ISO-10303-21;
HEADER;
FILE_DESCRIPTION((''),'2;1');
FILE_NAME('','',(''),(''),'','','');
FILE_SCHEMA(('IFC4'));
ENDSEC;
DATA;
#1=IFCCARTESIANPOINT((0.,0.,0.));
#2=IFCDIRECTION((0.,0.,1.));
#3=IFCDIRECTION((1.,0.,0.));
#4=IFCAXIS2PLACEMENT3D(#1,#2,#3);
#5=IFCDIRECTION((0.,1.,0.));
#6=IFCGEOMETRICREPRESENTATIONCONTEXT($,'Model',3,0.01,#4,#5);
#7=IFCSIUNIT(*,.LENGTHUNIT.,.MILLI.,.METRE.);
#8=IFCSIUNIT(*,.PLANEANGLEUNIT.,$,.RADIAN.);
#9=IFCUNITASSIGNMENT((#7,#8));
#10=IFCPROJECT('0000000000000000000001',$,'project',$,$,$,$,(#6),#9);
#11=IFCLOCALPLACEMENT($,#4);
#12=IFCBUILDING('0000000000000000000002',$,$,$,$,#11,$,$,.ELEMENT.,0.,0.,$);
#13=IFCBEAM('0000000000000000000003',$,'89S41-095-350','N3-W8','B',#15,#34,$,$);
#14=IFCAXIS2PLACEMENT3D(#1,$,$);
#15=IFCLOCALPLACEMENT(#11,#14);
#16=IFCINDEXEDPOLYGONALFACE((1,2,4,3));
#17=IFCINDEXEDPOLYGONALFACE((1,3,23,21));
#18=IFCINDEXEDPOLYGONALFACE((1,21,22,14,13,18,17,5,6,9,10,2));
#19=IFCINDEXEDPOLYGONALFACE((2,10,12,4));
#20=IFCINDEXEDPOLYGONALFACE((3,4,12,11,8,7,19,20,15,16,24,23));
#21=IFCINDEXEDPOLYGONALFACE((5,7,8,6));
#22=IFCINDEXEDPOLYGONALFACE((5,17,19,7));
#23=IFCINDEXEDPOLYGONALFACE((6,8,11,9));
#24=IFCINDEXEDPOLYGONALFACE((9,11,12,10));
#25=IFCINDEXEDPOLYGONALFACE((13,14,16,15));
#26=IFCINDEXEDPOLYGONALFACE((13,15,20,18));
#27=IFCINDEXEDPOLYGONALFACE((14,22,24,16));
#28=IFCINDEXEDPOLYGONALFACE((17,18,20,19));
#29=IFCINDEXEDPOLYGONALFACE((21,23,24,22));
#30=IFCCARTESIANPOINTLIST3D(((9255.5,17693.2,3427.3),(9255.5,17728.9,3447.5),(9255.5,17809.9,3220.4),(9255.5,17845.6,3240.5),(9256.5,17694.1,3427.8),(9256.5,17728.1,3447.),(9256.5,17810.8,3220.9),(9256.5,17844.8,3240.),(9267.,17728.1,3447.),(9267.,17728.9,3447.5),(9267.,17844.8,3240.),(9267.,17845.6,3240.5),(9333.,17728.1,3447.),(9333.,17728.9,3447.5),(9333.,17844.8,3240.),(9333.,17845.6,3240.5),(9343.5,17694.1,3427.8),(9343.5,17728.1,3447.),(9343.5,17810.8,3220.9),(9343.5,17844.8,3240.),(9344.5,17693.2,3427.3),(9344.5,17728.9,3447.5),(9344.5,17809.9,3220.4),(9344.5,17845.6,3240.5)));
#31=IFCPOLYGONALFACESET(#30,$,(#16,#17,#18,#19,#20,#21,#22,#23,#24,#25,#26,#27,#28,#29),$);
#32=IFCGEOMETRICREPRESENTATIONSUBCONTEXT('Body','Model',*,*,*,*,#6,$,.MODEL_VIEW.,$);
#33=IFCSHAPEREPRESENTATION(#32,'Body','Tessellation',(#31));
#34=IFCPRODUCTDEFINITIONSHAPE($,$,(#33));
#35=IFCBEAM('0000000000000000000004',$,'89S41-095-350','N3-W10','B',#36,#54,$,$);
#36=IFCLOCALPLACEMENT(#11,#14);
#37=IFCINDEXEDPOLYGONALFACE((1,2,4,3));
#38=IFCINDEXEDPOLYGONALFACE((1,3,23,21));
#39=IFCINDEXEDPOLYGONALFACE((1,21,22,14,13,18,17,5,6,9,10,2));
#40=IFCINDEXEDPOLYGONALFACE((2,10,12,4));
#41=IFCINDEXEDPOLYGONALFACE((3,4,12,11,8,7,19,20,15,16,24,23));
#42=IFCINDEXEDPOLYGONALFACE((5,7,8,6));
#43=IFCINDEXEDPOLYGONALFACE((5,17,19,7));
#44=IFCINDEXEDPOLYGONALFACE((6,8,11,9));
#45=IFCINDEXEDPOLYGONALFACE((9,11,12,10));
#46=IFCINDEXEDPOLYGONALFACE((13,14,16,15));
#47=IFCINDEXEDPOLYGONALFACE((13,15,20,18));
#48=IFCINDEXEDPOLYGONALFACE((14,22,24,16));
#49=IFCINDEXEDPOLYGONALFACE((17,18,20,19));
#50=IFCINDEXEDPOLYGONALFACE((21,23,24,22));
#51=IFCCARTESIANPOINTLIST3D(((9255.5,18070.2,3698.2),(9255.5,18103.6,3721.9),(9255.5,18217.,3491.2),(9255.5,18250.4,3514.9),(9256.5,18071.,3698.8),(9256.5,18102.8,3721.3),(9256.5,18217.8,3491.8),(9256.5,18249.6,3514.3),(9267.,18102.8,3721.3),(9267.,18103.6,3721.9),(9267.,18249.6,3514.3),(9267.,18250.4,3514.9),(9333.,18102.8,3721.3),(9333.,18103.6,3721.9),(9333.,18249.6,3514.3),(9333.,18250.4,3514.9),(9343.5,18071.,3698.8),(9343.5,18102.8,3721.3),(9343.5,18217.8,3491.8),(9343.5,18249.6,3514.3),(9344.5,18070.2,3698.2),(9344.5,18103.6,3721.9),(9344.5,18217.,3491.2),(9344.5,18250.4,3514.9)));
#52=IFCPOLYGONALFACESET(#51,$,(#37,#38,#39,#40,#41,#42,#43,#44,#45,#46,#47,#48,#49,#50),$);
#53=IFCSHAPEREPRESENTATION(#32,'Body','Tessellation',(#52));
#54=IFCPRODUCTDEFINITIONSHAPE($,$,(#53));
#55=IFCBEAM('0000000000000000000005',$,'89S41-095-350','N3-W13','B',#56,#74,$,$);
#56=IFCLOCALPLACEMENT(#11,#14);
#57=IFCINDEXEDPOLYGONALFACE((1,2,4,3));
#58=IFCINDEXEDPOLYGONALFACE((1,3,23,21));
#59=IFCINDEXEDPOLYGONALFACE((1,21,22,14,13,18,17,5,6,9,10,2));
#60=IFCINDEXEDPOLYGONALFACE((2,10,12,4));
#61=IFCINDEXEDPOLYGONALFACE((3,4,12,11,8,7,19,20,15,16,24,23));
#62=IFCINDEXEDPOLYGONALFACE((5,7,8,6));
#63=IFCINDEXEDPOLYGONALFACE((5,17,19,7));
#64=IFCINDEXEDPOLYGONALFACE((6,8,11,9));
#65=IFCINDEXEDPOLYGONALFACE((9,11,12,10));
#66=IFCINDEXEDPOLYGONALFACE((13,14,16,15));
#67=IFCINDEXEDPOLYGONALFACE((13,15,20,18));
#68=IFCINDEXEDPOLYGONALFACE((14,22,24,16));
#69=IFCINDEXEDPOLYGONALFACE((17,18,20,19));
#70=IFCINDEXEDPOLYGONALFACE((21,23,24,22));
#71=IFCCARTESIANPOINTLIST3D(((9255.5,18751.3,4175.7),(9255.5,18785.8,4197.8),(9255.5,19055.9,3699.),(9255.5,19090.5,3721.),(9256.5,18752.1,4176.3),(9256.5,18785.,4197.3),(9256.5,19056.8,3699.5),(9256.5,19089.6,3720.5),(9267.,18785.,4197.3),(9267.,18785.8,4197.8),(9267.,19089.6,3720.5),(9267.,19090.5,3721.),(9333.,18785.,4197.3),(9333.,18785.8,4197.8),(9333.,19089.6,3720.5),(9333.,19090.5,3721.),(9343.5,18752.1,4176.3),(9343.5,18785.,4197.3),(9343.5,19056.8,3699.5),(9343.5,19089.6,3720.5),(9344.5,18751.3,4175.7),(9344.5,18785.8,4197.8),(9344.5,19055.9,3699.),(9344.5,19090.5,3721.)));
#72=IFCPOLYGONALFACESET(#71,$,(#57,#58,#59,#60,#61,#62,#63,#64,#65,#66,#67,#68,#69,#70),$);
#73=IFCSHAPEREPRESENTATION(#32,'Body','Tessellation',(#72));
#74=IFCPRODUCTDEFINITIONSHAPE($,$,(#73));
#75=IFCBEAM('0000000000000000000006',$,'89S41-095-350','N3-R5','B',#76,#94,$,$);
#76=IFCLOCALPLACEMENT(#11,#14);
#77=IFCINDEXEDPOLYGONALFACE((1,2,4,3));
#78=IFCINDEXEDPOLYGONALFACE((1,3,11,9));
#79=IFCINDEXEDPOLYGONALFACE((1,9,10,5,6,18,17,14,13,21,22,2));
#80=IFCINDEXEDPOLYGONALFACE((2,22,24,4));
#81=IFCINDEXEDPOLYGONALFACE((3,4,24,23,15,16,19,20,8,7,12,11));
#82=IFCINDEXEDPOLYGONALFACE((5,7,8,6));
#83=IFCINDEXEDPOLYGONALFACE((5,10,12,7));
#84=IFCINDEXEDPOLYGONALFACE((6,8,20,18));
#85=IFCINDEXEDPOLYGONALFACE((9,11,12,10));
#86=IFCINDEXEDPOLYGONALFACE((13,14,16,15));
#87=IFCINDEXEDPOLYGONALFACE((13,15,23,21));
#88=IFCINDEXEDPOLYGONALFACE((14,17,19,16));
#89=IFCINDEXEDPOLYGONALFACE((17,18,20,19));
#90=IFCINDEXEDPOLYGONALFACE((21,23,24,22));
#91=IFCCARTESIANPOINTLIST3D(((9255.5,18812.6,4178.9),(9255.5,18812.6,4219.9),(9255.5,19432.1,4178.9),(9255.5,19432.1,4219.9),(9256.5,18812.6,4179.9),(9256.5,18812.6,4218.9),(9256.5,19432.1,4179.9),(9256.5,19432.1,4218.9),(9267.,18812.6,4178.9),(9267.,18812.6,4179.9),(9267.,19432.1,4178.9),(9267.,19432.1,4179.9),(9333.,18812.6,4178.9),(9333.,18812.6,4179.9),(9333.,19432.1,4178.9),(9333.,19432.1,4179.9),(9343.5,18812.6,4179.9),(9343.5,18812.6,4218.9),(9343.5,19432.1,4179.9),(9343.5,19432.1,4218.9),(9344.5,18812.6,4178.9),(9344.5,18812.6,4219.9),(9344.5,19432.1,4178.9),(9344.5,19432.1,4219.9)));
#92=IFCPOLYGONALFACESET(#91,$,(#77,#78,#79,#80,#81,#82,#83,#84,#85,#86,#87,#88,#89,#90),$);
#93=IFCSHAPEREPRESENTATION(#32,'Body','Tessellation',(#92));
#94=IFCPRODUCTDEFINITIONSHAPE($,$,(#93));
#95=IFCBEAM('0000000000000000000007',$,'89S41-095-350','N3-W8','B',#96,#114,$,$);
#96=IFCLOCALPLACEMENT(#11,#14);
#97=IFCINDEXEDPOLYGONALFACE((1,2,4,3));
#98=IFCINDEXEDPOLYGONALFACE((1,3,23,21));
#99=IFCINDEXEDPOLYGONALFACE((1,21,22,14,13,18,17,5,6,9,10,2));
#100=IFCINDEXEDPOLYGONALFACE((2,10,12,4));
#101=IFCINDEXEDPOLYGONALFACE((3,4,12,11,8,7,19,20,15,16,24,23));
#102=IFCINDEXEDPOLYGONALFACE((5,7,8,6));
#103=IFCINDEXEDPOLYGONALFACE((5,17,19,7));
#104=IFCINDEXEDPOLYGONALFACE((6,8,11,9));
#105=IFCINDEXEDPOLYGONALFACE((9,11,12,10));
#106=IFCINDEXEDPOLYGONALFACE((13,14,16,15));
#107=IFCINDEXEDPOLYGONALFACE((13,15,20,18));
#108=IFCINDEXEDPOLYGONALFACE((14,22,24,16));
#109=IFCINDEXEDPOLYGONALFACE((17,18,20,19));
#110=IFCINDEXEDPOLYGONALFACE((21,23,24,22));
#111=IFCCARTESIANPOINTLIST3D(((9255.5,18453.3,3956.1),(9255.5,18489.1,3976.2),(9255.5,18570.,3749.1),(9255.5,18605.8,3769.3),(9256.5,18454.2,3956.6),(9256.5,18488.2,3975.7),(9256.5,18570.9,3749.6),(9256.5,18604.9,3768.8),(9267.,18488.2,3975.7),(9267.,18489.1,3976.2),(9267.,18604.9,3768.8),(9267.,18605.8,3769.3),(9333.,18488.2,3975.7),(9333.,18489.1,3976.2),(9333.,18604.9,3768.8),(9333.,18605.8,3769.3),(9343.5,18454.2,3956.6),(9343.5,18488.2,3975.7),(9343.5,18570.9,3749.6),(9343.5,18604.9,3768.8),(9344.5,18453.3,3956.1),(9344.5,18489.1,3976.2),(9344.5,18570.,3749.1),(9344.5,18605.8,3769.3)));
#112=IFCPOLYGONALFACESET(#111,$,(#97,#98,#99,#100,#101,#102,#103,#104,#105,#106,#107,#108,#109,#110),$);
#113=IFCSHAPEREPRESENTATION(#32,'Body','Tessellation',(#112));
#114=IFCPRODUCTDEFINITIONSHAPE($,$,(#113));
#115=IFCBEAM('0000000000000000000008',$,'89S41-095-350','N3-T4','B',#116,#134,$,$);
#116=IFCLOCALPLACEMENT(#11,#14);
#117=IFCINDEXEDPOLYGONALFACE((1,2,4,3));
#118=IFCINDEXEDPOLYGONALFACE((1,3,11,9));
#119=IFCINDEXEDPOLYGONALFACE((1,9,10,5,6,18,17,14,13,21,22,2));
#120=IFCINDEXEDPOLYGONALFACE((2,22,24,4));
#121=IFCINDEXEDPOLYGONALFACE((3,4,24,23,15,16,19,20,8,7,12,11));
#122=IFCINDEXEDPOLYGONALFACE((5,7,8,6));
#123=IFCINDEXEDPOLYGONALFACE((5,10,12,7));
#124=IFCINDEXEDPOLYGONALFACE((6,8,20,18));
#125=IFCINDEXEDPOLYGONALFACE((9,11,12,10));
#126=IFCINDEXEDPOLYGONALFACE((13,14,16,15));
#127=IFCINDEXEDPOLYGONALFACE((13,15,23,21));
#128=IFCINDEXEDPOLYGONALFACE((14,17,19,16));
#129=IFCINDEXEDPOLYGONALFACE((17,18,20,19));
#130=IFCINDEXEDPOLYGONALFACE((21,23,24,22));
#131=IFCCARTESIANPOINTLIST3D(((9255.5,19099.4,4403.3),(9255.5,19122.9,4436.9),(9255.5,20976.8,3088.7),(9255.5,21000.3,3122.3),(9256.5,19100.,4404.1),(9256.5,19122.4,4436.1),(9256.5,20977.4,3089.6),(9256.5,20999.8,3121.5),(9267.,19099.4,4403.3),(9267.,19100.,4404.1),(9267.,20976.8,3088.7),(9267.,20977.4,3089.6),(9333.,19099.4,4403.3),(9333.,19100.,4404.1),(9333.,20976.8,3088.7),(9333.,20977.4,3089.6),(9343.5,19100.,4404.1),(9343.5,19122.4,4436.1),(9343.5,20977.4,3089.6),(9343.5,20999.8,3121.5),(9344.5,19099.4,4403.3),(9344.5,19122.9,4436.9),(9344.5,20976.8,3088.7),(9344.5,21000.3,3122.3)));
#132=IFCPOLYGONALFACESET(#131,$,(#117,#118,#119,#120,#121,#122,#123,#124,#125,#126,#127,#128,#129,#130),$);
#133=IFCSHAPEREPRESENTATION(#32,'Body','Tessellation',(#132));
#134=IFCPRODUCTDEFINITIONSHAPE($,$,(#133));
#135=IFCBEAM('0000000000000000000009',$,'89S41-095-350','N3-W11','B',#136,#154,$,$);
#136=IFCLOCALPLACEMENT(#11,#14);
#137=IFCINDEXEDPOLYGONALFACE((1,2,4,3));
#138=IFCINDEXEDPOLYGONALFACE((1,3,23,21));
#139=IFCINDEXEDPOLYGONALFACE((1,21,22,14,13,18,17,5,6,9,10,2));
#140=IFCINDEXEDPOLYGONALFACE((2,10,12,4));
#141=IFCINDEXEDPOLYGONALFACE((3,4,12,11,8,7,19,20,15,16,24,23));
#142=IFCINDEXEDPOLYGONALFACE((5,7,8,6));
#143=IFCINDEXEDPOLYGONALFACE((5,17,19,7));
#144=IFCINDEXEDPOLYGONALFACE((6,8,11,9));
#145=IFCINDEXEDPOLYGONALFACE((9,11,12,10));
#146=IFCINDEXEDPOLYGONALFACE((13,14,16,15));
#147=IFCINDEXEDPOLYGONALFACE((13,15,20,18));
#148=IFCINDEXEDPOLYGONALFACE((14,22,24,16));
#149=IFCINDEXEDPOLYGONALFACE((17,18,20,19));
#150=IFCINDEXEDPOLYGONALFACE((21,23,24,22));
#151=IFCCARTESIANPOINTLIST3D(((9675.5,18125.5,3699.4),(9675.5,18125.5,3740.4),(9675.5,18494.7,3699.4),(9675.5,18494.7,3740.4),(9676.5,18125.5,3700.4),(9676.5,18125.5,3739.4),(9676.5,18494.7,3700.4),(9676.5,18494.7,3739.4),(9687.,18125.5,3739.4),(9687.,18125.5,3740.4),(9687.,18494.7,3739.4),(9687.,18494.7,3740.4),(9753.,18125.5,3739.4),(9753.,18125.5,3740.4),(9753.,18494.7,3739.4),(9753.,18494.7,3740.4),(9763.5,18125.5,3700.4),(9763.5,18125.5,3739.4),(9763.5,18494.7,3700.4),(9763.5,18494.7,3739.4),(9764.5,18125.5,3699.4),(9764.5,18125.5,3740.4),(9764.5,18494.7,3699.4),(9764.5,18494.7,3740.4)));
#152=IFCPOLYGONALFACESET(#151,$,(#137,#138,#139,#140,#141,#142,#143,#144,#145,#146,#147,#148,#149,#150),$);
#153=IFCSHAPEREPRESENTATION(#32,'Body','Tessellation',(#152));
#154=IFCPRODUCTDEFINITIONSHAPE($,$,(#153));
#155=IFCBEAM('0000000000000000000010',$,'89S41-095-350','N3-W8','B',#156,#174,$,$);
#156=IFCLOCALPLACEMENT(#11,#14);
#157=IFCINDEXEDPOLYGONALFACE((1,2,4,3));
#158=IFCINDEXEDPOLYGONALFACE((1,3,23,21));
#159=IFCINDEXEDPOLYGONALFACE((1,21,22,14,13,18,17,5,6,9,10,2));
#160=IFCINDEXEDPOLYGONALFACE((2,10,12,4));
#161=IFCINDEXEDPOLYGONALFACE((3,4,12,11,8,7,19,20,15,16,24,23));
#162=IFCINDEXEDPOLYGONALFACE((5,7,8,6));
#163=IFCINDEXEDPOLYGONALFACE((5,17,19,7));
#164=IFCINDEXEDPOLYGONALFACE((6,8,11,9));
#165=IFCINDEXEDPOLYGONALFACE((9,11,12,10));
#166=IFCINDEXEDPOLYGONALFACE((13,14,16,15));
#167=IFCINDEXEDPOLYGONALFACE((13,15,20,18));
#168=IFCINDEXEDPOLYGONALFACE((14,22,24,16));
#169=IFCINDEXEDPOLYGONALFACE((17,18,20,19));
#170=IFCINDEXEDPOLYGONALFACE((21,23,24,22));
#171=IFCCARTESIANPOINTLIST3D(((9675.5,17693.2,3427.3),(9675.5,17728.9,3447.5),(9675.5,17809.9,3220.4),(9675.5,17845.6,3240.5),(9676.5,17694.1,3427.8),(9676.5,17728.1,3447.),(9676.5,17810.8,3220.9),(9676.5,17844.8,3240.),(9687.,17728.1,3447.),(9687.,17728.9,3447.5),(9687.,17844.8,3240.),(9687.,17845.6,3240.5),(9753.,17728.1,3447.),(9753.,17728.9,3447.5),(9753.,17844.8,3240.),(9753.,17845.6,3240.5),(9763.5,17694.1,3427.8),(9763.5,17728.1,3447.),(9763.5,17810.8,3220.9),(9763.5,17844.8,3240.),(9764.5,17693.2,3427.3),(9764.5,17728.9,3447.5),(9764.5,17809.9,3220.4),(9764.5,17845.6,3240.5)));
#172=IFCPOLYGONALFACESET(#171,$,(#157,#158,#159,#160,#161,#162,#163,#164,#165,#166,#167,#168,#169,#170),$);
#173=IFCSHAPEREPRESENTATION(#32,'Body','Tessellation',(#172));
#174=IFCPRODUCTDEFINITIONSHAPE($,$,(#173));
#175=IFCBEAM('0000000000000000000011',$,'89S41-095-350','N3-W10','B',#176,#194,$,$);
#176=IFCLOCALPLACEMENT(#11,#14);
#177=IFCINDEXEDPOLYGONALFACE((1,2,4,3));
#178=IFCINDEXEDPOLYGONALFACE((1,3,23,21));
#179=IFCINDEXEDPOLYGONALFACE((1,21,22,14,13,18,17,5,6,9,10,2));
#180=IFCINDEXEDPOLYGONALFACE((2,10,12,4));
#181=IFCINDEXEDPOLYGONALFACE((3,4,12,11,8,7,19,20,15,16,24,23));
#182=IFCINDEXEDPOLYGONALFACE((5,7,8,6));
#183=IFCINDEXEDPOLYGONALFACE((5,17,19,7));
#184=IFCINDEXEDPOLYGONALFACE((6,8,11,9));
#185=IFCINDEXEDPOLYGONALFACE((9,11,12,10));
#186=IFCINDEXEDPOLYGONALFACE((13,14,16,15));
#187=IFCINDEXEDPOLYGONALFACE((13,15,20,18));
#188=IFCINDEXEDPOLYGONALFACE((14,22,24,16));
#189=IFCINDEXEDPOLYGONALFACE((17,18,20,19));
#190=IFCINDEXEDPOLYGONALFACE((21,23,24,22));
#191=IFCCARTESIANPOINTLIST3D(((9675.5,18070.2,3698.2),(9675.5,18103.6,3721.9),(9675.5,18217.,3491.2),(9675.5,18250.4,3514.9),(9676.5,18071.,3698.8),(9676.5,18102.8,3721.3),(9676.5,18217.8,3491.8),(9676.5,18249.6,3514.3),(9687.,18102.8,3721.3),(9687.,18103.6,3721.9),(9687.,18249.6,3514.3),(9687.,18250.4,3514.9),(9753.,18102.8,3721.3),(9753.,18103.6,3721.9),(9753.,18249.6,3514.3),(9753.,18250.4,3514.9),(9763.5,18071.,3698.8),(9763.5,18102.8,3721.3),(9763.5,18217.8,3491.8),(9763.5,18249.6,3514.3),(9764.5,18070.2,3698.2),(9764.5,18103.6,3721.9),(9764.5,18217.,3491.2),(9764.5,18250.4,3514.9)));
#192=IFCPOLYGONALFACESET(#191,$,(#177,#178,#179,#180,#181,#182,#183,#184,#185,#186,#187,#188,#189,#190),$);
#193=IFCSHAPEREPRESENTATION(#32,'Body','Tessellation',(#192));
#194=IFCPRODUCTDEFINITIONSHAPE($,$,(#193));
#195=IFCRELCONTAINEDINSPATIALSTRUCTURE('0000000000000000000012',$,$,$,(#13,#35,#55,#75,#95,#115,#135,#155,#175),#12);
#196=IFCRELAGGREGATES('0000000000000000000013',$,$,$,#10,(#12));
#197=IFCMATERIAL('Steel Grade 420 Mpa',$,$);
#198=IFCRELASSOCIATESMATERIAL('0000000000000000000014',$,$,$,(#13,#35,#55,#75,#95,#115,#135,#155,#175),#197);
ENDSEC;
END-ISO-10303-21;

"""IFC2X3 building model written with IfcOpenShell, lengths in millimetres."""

from ifc_helpers import new_model, si_unit, direction, frame, origin, origin_with_axes, origin_2d_with_axis, place, context, subcontext, project, spatial, c_section, extrude, source, transform, mapped, material, element, save


model = new_model("IFC2X3")

# Units and contexts
model_context = context("Model", 3, precision=0.01, world=origin_with_axes(), true_north=direction((0.0, 1.0, 0.0)))
body_context = subcontext(model_context, "Body", "Model", "MODEL_VIEW")
ifc_project = project(units=[si_unit("LENGTHUNIT", "METRE", prefix="MILLI"), si_unit("PLANEANGLEUNIT", "RADIAN")], contexts=[model_context])

# Building
building_placement = place(None, origin_with_axes())
building = spatial("IfcBuilding", under=ifc_project, at=building_placement, CompositionType="ELEMENT", ElevationOfRefHeight=0.0, ElevationOfTerrain=0.0)

# Shared definitions
ifc_material = material(Name="Steel Grade 420 Mpa")

# Beams
shared_shape_1 = source(origin(), body_context, "Body", "SweptSolid", [
    extrude(c_section(Depth=89.0, Width=41.0, WallThickness=1.0, Girth=11.5, at=origin_2d_with_axis()), origin_with_axes(), (0.0, 0.0, 1.0), 237.6),
])
beam_1_placement = place(None, frame((9300.0, 17827.8, 3230.5), z_axis=(0.0, -0.491169, 0.871064), x_axis=(0.0, 0.871064, 0.491169)))
element("IfcBeam", 1, at=beam_1_placement, inside=building, material=ifc_material, Name="89S41-095-350", Description="N3-W8", ObjectType="B", context=body_context, shape_type="MappedRepresentation", body=[
    mapped(shared_shape_1, transform((0.0, 0.0, 0.0), scale=1.0)),
])
shared_shape_2 = source(origin(), body_context, "Body", "SweptSolid", [
    extrude(c_section(Depth=89.0, Width=41.0, WallThickness=1.0, Girth=11.5, at=origin_2d_with_axis()), origin_with_axes(), (0.0, 0.0, 1.0), 253.8),
])
beam_2_placement = place(None, frame((9300.0, 18233.7, 3503.0), z_axis=(0.0, -0.578484, 0.815694), x_axis=(0.0, 0.815694, 0.578484)))
element("IfcBeam", 2, at=beam_2_placement, inside=building, material=ifc_material, Name="89S41-095-350", Description="N3-W10", ObjectType="B", context=body_context, shape_type="MappedRepresentation", body=[
    mapped(shared_shape_2, transform((0.0, 0.0, 0.0), scale=1.0)),
])
shared_shape_3 = source(origin(), body_context, "Body", "SweptSolid", [
    extrude(c_section(Depth=89.0, Width=41.0, WallThickness=1.0, Girth=11.5, at=origin_2d_with_axis()), origin_with_axes(), (0.0, 0.0, 1.0), 565.8),
])
beam_3_placement = place(None, frame((9300.0, 19073.2, 3710.0), z_axis=(0.0, -0.538498, 0.842627), x_axis=(0.0, 0.842627, 0.538498)))
element("IfcBeam", 3, at=beam_3_placement, inside=building, material=ifc_material, Name="89S41-095-350", Description="N3-W13", ObjectType="B", context=body_context, shape_type="MappedRepresentation", body=[
    mapped(shared_shape_3, transform((0.0, 0.0, 0.0), scale=1.0)),
])
shared_shape_4 = source(origin(), body_context, "Body", "SweptSolid", [
    extrude(c_section(Depth=89.0, Width=41.0, WallThickness=1.0, Girth=11.5, at=origin_2d_with_axis()), origin_with_axes(), (0.0, 0.0, 1.0), 619.5),
])
beam_4_placement = place(None, frame((9300.0, 18812.6, 4199.4), z_axis=(0.0, 1.0, 0.0), x_axis=(0.0, 0.0, -1.0)))
element("IfcBeam", 4, at=beam_4_placement, inside=building, material=ifc_material, Name="89S41-095-350", Description="N3-R5", ObjectType="B", context=body_context, shape_type="MappedRepresentation", body=[
    mapped(shared_shape_4, transform((0.0, 0.0, 0.0), scale=1.0)),
])
shared_shape_5 = source(origin(), body_context, "Body", "SweptSolid", [
    extrude(c_section(Depth=89.0, Width=41.0, WallThickness=1.0, Girth=11.5, at=origin_2d_with_axis()), origin_with_axes(), (0.0, 0.0, 1.0), 237.6),
])
beam_5_placement = place(None, frame((9300.0, 18587.9, 3759.2), z_axis=(0.0, -0.491169, 0.871064), x_axis=(0.0, 0.871064, 0.491169)))
element("IfcBeam", 5, at=beam_5_placement, inside=building, material=ifc_material, Name="89S41-095-350", Description="N3-W8", ObjectType="B", context=body_context, shape_type="MappedRepresentation", body=[
    mapped(shared_shape_5, transform((0.0, 0.0, 0.0), scale=1.0)),
])
shared_shape_6 = source(origin(), body_context, "Body", "SweptSolid", [
    extrude(c_section(Depth=89.0, Width=41.0, WallThickness=1.0, Girth=11.5, at=origin_2d_with_axis()), origin_with_axes(), (0.0, 0.0, 1.0), 2291.9),
])
beam_6_placement = place(None, frame((9300.0, 19111.2, 4420.1), z_axis=(0.0, 0.819152, -0.573576), x_axis=(0.0, -0.573576, -0.819152)))
element("IfcBeam", 6, at=beam_6_placement, inside=building, material=ifc_material, Name="89S41-095-350", Description="N3-T4", ObjectType="B", context=body_context, shape_type="MappedRepresentation", body=[
    mapped(shared_shape_6, transform((0.0, 0.0, 0.0), scale=1.0)),
])
shared_shape_7 = source(origin(), body_context, "Body", "SweptSolid", [
    extrude(c_section(Depth=89.0, Width=41.0, WallThickness=1.0, Girth=11.5, at=origin_2d_with_axis()), origin_with_axes(), (0.0, 0.0, 1.0), 369.2),
])
beam_7_placement = place(None, frame((9720.0, 18494.7, 3719.9), z_axis=(0.0, -1.0, 0.0), x_axis=(0.0, 0.0, 1.0)))
element("IfcBeam", 7, at=beam_7_placement, inside=building, material=ifc_material, Name="89S41-095-350", Description="N3-W11", ObjectType="B", context=body_context, shape_type="MappedRepresentation", body=[
    mapped(shared_shape_7, transform((0.0, 0.0, 0.0), scale=1.0)),
])
shared_shape_8 = source(origin(), body_context, "Body", "SweptSolid", [
    extrude(c_section(Depth=89.0, Width=41.0, WallThickness=1.0, Girth=11.5, at=origin_2d_with_axis()), origin_with_axes(), (0.0, 0.0, 1.0), 237.6),
])
beam_8_placement = place(None, frame((9720.0, 17827.8, 3230.5), z_axis=(0.0, -0.491169, 0.871064), x_axis=(0.0, 0.871064, 0.491169)))
element("IfcBeam", 8, at=beam_8_placement, inside=building, material=ifc_material, Name="89S41-095-350", Description="N3-W8", ObjectType="B", context=body_context, shape_type="MappedRepresentation", body=[
    mapped(shared_shape_8, transform((0.0, 0.0, 0.0), scale=1.0)),
])
shared_shape_9 = source(origin(), body_context, "Body", "SweptSolid", [
    extrude(c_section(Depth=89.0, Width=41.0, WallThickness=1.0, Girth=11.5, at=origin_2d_with_axis()), origin_with_axes(), (0.0, 0.0, 1.0), 253.8),
])
beam_9_placement = place(None, frame((9720.0, 18233.7, 3503.0), z_axis=(0.0, -0.578484, 0.815694), x_axis=(0.0, 0.815694, 0.578484)))
element("IfcBeam", 9, at=beam_9_placement, inside=building, material=ifc_material, Name="89S41-095-350", Description="N3-W10", ObjectType="B", context=body_context, shape_type="MappedRepresentation", body=[
    mapped(shared_shape_9, transform((0.0, 0.0, 0.0), scale=1.0)),
])

save(model, "model.ifc")
